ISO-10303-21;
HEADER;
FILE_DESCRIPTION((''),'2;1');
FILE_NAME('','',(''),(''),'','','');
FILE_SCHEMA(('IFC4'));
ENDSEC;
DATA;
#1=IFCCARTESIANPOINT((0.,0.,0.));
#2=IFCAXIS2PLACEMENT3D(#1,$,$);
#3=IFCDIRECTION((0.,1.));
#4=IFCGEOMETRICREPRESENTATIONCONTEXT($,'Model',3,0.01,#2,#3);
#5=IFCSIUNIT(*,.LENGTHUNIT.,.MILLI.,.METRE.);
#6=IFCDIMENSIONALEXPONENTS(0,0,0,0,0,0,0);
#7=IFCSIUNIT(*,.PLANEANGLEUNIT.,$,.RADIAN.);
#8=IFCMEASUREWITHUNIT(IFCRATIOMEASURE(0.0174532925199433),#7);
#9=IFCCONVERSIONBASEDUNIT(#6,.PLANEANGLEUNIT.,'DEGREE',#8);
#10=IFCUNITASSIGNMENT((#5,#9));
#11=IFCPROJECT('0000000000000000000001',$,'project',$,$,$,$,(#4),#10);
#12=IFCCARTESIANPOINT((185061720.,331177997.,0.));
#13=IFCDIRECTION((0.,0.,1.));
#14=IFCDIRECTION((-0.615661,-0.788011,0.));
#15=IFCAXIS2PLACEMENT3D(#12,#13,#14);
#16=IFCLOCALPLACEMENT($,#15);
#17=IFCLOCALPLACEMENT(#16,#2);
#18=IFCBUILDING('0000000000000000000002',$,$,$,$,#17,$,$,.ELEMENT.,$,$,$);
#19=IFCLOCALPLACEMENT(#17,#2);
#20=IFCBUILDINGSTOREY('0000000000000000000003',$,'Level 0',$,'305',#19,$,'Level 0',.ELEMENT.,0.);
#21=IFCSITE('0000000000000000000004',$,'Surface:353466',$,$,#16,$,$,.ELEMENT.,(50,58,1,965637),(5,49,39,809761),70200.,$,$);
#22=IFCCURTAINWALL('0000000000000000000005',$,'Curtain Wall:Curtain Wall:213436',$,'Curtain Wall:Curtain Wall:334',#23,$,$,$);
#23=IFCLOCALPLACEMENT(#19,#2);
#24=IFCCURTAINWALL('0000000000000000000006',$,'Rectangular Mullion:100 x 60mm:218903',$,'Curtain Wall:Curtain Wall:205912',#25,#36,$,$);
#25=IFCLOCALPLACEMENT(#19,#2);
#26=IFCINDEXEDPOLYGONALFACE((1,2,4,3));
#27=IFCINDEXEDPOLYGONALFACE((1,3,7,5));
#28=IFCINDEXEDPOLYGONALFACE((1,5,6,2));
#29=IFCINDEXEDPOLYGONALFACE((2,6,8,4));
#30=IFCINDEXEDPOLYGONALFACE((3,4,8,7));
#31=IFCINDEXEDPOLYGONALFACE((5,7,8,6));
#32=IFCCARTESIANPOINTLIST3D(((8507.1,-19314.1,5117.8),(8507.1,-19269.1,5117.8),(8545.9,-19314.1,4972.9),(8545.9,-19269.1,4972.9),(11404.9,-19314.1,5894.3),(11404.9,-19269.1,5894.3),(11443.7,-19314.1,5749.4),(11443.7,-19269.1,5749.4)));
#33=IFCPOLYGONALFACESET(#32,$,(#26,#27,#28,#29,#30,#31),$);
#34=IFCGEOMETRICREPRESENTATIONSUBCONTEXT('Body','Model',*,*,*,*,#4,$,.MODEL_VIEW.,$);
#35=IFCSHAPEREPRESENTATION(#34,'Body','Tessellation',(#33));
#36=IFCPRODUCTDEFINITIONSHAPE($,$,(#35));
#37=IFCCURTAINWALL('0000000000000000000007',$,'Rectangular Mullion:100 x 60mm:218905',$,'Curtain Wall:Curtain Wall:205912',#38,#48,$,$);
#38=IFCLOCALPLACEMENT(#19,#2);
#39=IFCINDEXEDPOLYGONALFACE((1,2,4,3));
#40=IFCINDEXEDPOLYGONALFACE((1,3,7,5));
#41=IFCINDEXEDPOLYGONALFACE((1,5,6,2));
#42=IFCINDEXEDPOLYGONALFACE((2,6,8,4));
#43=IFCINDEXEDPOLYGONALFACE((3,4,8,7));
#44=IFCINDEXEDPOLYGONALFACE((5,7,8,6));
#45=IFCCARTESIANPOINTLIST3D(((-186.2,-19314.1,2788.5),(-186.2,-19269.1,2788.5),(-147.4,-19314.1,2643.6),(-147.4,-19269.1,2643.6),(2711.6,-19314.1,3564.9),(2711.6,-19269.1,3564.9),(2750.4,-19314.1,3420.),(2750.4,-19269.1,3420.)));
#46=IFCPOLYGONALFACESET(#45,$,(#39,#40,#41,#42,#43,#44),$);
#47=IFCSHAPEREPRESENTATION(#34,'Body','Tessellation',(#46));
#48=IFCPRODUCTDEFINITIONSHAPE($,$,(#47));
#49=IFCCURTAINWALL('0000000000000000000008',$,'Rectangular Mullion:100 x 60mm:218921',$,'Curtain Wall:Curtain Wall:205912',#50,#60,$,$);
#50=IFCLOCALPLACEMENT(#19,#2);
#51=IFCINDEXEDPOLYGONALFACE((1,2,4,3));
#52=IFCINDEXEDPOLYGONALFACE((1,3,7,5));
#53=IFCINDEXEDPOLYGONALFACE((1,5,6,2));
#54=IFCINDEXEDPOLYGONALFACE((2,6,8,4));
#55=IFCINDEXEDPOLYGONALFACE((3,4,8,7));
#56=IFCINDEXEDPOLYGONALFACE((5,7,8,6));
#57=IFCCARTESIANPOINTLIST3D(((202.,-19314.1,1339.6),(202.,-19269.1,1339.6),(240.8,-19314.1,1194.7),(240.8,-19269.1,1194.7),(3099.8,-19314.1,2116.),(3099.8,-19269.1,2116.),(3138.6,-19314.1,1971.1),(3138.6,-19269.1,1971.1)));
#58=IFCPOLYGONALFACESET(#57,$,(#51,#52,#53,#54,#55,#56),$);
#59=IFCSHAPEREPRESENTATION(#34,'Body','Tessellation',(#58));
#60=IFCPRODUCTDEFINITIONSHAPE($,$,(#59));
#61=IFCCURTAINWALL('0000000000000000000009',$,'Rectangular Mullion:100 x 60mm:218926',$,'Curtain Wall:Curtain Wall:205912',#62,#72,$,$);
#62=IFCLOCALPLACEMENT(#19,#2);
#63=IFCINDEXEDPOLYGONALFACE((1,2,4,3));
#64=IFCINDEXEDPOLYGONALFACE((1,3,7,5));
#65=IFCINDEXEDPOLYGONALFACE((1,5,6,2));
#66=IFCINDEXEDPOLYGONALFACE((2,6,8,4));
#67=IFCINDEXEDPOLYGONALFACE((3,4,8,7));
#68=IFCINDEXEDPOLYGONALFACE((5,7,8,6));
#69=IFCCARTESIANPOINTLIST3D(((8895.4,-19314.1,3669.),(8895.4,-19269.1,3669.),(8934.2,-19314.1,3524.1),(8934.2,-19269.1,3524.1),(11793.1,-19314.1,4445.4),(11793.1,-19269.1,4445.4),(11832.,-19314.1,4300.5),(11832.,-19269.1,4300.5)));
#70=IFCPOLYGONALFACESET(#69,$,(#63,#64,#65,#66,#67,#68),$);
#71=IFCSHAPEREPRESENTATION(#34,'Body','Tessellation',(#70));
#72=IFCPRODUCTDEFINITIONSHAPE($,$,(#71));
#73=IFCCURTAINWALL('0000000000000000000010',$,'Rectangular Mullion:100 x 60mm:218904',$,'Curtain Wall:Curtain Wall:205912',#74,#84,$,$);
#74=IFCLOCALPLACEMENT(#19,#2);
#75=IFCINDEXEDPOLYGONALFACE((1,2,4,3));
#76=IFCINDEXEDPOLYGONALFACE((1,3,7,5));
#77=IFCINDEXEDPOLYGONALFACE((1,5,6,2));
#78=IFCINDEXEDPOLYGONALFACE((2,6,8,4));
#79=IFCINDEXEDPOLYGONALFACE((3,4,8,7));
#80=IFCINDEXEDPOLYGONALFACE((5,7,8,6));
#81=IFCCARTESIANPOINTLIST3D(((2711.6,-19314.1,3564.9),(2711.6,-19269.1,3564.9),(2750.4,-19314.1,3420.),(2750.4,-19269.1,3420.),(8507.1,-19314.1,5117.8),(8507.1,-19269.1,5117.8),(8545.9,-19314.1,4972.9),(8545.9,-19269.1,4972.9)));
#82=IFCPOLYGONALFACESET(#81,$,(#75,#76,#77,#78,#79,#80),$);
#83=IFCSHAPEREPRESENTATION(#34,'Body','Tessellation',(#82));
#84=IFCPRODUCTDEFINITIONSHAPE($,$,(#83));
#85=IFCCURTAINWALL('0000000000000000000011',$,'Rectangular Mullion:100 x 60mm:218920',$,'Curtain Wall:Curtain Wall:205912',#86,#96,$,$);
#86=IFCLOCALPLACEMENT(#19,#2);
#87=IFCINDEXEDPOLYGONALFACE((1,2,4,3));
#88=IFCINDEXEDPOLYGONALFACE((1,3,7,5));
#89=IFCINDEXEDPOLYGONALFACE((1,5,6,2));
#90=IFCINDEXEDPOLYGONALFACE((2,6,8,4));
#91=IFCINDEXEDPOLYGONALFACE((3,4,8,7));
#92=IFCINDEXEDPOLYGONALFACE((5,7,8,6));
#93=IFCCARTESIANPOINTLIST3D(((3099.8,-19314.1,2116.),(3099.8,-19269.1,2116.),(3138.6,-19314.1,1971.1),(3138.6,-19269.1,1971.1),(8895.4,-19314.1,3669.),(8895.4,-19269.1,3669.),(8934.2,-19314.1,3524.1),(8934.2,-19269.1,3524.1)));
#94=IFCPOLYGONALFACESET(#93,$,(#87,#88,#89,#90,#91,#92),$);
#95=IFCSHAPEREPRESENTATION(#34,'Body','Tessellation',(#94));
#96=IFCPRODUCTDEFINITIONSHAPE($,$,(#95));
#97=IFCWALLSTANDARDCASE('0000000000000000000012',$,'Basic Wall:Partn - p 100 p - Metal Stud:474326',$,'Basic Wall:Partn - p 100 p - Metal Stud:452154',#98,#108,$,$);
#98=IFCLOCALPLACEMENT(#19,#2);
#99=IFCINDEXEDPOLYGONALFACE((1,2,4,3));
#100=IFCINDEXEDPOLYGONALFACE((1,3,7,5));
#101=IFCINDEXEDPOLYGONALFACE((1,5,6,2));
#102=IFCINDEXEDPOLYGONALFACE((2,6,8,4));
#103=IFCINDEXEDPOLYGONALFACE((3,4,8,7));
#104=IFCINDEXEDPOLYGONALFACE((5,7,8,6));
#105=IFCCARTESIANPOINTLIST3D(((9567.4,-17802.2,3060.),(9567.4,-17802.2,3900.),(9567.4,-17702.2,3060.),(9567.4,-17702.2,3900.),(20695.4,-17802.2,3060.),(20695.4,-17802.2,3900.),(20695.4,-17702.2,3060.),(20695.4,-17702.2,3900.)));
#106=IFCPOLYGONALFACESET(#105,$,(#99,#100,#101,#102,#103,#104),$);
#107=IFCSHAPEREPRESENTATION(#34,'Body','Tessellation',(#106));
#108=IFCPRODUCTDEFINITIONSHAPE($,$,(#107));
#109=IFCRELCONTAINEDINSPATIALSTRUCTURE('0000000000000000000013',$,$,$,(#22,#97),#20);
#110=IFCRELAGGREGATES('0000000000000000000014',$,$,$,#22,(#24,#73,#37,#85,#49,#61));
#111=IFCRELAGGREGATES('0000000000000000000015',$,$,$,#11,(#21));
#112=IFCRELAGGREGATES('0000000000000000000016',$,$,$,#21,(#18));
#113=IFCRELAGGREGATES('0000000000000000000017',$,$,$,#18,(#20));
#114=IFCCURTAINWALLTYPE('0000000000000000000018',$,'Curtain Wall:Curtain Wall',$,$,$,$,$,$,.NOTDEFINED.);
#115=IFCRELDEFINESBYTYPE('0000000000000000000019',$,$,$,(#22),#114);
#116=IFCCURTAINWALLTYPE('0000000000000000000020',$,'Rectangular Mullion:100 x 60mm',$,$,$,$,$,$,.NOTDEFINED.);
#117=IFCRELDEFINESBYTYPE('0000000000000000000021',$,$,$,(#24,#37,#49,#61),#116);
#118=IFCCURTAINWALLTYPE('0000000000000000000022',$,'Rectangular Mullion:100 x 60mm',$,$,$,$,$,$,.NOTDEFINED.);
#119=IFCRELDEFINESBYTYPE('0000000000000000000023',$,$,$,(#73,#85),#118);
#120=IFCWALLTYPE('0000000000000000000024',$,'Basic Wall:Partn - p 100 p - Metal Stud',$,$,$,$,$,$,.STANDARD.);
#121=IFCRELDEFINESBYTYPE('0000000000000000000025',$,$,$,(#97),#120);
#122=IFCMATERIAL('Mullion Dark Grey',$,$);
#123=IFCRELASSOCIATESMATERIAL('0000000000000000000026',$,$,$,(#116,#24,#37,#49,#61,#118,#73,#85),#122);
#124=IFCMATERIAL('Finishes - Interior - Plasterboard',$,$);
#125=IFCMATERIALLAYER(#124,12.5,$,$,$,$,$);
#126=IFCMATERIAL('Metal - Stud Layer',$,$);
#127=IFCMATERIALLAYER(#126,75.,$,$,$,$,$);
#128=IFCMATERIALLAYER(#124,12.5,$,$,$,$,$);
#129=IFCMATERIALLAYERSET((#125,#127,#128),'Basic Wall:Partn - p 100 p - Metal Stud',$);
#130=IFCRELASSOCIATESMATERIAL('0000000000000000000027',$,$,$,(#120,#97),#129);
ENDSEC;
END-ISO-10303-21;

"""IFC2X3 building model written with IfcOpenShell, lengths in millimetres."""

from ifc_helpers import new_model, entity, si_unit, converted_unit, direction, frame, frame_2d, origin, place, context, subcontext, project, spatial, rectangle, extrude, source, transform, mapped, material, layer, layer_set, layer_usage, type_object, type_shapes, element, aggregate, save


model = new_model("IFC2X3")

# Units and contexts
model_context = context("Model", 3, precision=0.01, world=origin(), true_north=direction((0.0, 1.0)))
body_context = subcontext(model_context, "Body", "Model", "MODEL_VIEW")
ifc_project = project(units=[si_unit("LENGTHUNIT", "METRE", prefix="MILLI"), converted_unit("PLANEANGLEUNIT", "DEGREE", entity("IfcRatioMeasure", 0.0174532925199433), si_unit("PLANEANGLEUNIT", "RADIAN"), dimensions=[0, 0, 0, 0, 0, 0, 0])], contexts=[model_context])

# Site, building, storey
site_placement = place(None, frame((185061720.0, 331177997.0, 0.0), z_axis=(0.0, 0.0, 1.0), x_axis=(-0.615661, -0.788011, 0.0)))
site = spatial("IfcSite", under=ifc_project, at=site_placement, Name="Surface:353466", CompositionType="ELEMENT", RefLatitude=(50, 58, 1, 965637), RefLongitude=(5, 49, 39, 809761), RefElevation=70200.0)
building_placement = place(site_placement, origin())
building = spatial("IfcBuilding", under=site, at=building_placement, CompositionType="ELEMENT")
storey_placement = place(building_placement, origin())
storey = spatial("IfcBuildingStorey", under=building, at=storey_placement, Name="Level 0", ObjectType="305", LongName="Level 0", CompositionType="ELEMENT", Elevation=0.0)

# Curtain walls
curtain_wall_type_1 = type_object("IfcCurtainWallType", Name="Curtain Wall:Curtain Wall", PredefinedType="NOTDEFINED")
curtain_wall_1_placement = place(storey_placement, origin())
curtain_wall_1 = element("IfcCurtainWall", 1, at=curtain_wall_1_placement, inside=storey, type_object=curtain_wall_type_1, Name="Curtain Wall:Curtain Wall:213436", ObjectType="Curtain Wall:Curtain Wall:334")
ifc_material_1 = material(Name="Mullion Dark Grey")
curtain_wall_type_2 = type_object("IfcCurtainWallType", Name="Rectangular Mullion:100 x 60mm", PredefinedType="NOTDEFINED", material=ifc_material_1)
shared_shape_1 = source(origin(), body_context, "Body", "SweptSolid", [
    extrude(rectangle(XDim=150.0, YDim=45.0, at=frame_2d((0.0, 0.0), x_axis=(1.0, 0.0))), frame((0.0, -7.5, -3000.0)), (0.0, 0.0, 1.0), 3000.0),
])
type_shapes(curtain_wall_type_2, [shared_shape_1])
curtain_wall_2_placement = place(storey_placement, frame((11424.3, -19299.1, 5821.9), z_axis=(0.965926, 0.0, 0.258819), x_axis=(-0.258819, 0.0, 0.965926)))
curtain_wall_2 = element("IfcCurtainWall", 2, at=curtain_wall_2_placement, type_object=curtain_wall_type_2, material=ifc_material_1, Name="Rectangular Mullion:100 x 60mm:218903", ObjectType="Curtain Wall:Curtain Wall:205912", context=body_context, shape_type="MappedRepresentation", body=[
    mapped(shared_shape_1, transform((0.0, 0.0, 0.0), scale=1.0)),
])
curtain_wall_3_placement = place(storey_placement, frame((2731.0, -19299.1, 3492.5), z_axis=(0.965926, 0.0, 0.258819), x_axis=(-0.258819, 0.0, 0.965926)))
curtain_wall_3 = element("IfcCurtainWall", 3, at=curtain_wall_3_placement, type_object=curtain_wall_type_2, material=ifc_material_1, Name="Rectangular Mullion:100 x 60mm:218905", ObjectType="Curtain Wall:Curtain Wall:205912", context=body_context, shape_type="MappedRepresentation", body=[
    mapped(shared_shape_1, transform((0.0, 0.0, 0.0), scale=1.0)),
])
curtain_wall_4_placement = place(storey_placement, frame((3119.2, -19299.1, 2043.6), z_axis=(0.965926, 0.0, 0.258819), x_axis=(-0.258819, 0.0, 0.965926)))
curtain_wall_4 = element("IfcCurtainWall", 4, at=curtain_wall_4_placement, type_object=curtain_wall_type_2, material=ifc_material_1, Name="Rectangular Mullion:100 x 60mm:218921", ObjectType="Curtain Wall:Curtain Wall:205912", context=body_context, shape_type="MappedRepresentation", body=[
    mapped(shared_shape_1, transform((0.0, 0.0, 0.0), scale=1.0)),
])
curtain_wall_5_placement = place(storey_placement, frame((11812.5, -19299.1, 4373.0), z_axis=(0.965926, 0.0, 0.258819), x_axis=(-0.258819, 0.0, 0.965926)))
curtain_wall_5 = element("IfcCurtainWall", 5, at=curtain_wall_5_placement, type_object=curtain_wall_type_2, material=ifc_material_1, Name="Rectangular Mullion:100 x 60mm:218926", ObjectType="Curtain Wall:Curtain Wall:205912", context=body_context, shape_type="MappedRepresentation", body=[
    mapped(shared_shape_1, transform((0.0, 0.0, 0.0), scale=1.0)),
])
curtain_wall_type_3 = type_object("IfcCurtainWallType", Name="Rectangular Mullion:100 x 60mm", PredefinedType="NOTDEFINED", material=ifc_material_1)
shared_shape_2 = source(origin(), body_context, "Body", "SweptSolid", [
    extrude(rectangle(XDim=150.0, YDim=45.0, at=frame_2d((0.0, 0.0), x_axis=(1.0, 0.0))), frame((0.0, -7.5, -6000.0)), (0.0, 0.0, 1.0), 6000.0),
])
type_shapes(curtain_wall_type_3, [shared_shape_2])
curtain_wall_6_placement = place(storey_placement, frame((8526.5, -19299.1, 5045.4), z_axis=(0.965926, 0.0, 0.258819), x_axis=(-0.258819, 0.0, 0.965926)))
curtain_wall_6 = element("IfcCurtainWall", 6, at=curtain_wall_6_placement, type_object=curtain_wall_type_3, material=ifc_material_1, Name="Rectangular Mullion:100 x 60mm:218904", ObjectType="Curtain Wall:Curtain Wall:205912", context=body_context, shape_type="MappedRepresentation", body=[
    mapped(shared_shape_2, transform((0.0, 0.0, 0.0), scale=1.0)),
])
curtain_wall_7_placement = place(storey_placement, frame((8914.8, -19299.1, 3596.5), z_axis=(0.965926, 0.0, 0.258819), x_axis=(-0.258819, 0.0, 0.965926)))
curtain_wall_7 = element("IfcCurtainWall", 7, at=curtain_wall_7_placement, type_object=curtain_wall_type_3, material=ifc_material_1, Name="Rectangular Mullion:100 x 60mm:218920", ObjectType="Curtain Wall:Curtain Wall:205912", context=body_context, shape_type="MappedRepresentation", body=[
    mapped(shared_shape_2, transform((0.0, 0.0, 0.0), scale=1.0)),
])
aggregate(curtain_wall_1, [curtain_wall_2, curtain_wall_6, curtain_wall_3, curtain_wall_7, curtain_wall_4, curtain_wall_5])

# Wall
ifc_material_2 = material(Name="Finishes - Interior - Plasterboard")
ifc_layer_1 = layer(ifc_material_2, 12.5)
ifc_material_3 = material(Name="Metal - Stud Layer")
ifc_layer_2 = layer(ifc_material_3, 75.0)
ifc_layer_3 = layer(ifc_material_2, 12.5)
ifc_layer_set = layer_set([ifc_layer_1, ifc_layer_2, ifc_layer_3], Name="Basic Wall:Partn - p 100 p - Metal Stud")
ifc_layer_usage = layer_usage(ifc_layer_set, "AXIS2", "POSITIVE", -50.0)
wall_type = type_object("IfcWallType", Name="Basic Wall:Partn - p 100 p - Metal Stud", PredefinedType="STANDARD", material=ifc_layer_set)
wall_placement = place(storey_placement, frame((9567.4, -17752.2, 3060.0)))
element("IfcWallStandardCase", 8, at=wall_placement, inside=storey, type_object=wall_type, material=ifc_layer_usage, Name="Basic Wall:Partn - p 100 p - Metal Stud:474326", ObjectType="Basic Wall:Partn - p 100 p - Metal Stud:452154", context=body_context, shape_type="SweptSolid", body=[
    extrude(rectangle(XDim=11128.0, YDim=100.0, at=frame_2d((5564.0, 0.0), x_axis=(-1.0, 0.0))), origin(), (0.0, 0.0, 1.0), 840.0),
])

save(model, "model.ifc")
